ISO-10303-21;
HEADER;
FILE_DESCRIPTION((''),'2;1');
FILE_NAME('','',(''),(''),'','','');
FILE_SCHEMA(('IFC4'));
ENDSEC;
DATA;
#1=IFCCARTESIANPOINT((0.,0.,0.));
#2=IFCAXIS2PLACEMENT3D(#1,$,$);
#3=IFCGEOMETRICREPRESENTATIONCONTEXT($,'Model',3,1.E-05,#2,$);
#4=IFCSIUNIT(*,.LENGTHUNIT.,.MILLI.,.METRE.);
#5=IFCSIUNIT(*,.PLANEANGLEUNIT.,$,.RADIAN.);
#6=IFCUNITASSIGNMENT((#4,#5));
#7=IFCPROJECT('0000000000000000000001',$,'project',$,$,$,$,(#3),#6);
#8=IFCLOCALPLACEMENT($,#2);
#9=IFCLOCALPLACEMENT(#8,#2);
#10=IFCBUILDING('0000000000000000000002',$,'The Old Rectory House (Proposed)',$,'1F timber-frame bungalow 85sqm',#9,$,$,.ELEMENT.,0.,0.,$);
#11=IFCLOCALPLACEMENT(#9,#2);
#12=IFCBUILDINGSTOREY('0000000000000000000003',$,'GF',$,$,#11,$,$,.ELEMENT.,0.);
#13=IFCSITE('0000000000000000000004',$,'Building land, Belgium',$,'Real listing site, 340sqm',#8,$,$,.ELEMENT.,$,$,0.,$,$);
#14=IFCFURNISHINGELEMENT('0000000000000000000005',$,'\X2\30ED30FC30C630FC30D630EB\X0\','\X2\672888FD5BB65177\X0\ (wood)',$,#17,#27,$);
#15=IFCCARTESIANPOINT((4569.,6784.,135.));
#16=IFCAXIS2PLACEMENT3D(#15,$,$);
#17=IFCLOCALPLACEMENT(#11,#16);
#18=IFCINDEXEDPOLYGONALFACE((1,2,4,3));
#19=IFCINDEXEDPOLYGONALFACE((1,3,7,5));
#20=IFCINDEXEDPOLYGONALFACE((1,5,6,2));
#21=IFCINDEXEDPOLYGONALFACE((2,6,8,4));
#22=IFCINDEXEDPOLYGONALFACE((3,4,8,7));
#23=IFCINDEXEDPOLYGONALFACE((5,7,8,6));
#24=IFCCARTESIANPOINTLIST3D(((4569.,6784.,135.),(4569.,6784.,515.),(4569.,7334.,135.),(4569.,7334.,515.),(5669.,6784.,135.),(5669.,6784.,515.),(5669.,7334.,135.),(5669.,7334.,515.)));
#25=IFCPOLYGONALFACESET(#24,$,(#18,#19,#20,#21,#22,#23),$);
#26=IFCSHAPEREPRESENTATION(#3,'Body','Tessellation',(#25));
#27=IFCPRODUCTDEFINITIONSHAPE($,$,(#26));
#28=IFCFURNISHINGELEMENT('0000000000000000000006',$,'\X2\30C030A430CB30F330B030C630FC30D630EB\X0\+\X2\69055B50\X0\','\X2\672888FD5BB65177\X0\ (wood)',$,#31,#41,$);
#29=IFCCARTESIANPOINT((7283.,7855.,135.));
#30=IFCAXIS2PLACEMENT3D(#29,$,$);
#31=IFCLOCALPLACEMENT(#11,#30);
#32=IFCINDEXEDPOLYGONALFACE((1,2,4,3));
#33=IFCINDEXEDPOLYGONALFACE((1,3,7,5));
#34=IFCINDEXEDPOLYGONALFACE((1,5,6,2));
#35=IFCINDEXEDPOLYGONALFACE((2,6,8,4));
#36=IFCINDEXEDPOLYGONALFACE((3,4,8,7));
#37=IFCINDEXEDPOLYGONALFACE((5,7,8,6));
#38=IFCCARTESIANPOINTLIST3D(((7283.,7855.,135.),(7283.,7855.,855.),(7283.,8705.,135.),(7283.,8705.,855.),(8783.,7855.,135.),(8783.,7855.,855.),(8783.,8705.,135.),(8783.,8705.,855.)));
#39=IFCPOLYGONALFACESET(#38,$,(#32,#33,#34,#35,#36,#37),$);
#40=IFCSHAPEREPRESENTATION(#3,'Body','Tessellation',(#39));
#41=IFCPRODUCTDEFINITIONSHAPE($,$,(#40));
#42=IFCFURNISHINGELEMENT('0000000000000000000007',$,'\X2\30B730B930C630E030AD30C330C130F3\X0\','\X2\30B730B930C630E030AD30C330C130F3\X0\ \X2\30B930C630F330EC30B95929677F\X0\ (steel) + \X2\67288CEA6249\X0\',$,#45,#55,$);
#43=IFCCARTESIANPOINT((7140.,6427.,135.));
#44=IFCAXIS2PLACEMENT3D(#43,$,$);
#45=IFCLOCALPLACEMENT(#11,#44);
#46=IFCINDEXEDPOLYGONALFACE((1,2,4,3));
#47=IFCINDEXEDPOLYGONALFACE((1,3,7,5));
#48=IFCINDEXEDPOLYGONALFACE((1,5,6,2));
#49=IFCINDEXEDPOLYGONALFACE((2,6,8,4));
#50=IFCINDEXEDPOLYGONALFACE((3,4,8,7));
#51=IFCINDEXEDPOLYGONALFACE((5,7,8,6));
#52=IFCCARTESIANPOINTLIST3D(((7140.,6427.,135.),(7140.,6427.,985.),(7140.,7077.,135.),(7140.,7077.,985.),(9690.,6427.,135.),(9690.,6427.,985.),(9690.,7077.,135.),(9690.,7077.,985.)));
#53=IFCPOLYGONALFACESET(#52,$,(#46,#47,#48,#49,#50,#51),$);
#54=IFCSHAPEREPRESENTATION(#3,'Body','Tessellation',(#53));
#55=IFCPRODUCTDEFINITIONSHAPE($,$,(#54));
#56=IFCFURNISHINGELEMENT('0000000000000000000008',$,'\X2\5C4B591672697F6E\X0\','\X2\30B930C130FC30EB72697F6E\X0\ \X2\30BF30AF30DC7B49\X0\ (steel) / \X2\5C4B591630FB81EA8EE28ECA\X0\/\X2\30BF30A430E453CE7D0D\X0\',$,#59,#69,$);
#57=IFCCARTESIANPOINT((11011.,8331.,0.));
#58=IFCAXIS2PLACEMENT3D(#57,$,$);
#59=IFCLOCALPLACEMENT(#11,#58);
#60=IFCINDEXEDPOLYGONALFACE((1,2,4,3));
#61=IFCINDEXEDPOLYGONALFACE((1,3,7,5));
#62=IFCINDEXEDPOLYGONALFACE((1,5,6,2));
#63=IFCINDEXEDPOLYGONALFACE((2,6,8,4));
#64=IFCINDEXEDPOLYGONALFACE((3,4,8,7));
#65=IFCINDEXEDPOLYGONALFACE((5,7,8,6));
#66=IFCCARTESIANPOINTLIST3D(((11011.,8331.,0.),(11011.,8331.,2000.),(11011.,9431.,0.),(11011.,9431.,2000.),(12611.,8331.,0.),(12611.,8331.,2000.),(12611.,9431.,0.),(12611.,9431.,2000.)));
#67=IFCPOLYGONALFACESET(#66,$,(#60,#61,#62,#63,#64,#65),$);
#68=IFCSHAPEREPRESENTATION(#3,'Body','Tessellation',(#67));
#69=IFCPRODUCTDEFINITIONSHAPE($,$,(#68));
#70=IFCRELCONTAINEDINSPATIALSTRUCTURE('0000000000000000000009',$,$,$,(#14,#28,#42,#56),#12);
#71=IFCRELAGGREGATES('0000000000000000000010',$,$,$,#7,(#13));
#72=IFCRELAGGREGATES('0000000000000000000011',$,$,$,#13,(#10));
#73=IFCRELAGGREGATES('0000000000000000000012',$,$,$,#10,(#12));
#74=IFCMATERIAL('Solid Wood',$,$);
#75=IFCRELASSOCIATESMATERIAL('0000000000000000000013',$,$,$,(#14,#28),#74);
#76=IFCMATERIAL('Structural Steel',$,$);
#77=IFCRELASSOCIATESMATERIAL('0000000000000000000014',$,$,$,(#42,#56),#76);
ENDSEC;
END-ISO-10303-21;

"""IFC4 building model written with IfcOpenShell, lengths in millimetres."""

from ifc_helpers import new_model, si_unit, frame, frame_2d, origin, place, context, project, spatial, rectangle, extrude, material, element, save


model = new_model("IFC4")

# Units and contexts
model_context = context("Model", 3, precision=1e-05, world=origin())
ifc_project = project(units=[si_unit("LENGTHUNIT", "METRE", prefix="MILLI"), si_unit("PLANEANGLEUNIT", "RADIAN")], contexts=[model_context])

# Site, building, storey
site_placement = place(None, origin())
site = spatial("IfcSite", under=ifc_project, at=site_placement, Name="Building land, Belgium", ObjectType="Real listing site, 340sqm", CompositionType="ELEMENT", RefElevation=0.0)
building_placement = place(site_placement, origin())
building = spatial("IfcBuilding", under=site, at=building_placement, Name="The Old Rectory House (Proposed)", ObjectType="1F timber-frame bungalow 85sqm", CompositionType="ELEMENT", ElevationOfRefHeight=0.0, ElevationOfTerrain=0.0)
storey_placement = place(building_placement, origin())
storey = spatial("IfcBuildingStorey", under=building, at=storey_placement, Name="GF", CompositionType="ELEMENT", Elevation=0.0)

# Shared definitions
ifc_material_1 = material(Name="Solid Wood")

# Shared definitions
ifc_material_2 = material(Name="Structural Steel")

# Furnishing elements
furnishing_1_placement = place(storey_placement, frame((4569.0, 6784.0, 135.0)))
element("IfcFurnishingElement", 1, at=furnishing_1_placement, inside=storey, material=ifc_material_1, Name="ローテーブル", Description="木製家具 (wood)", context=model_context, shape_type="SweptSolid", body=[
    extrude(rectangle(XDim=1100.0, YDim=550.0, at=frame_2d((550.0, 275.0))), frame((4569.0, 6784.0, 135.0)), (0.0, 0.0, 1.0), 380.0),
])
furnishing_2_placement = place(storey_placement, frame((7283.0, 7855.0, 135.0)))
element("IfcFurnishingElement", 2, at=furnishing_2_placement, inside=storey, material=ifc_material_1, Name="ダイニングテーブル+椅子", Description="木製家具 (wood)", context=model_context, shape_type="SweptSolid", body=[
    extrude(rectangle(XDim=1500.0, YDim=850.0, at=frame_2d((750.0, 425.0))), frame((7283.0, 7855.0, 135.0)), (0.0, 0.0, 1.0), 720.0),
])
furnishing_3_placement = place(storey_placement, frame((7140.0, 6427.0, 135.0)))
element("IfcFurnishingElement", 3, at=furnishing_3_placement, inside=storey, material=ifc_material_2, Name="システムキッチン", Description="システムキッチン ステンレス天板 (steel) + 木質扉", context=model_context, shape_type="SweptSolid", body=[
    extrude(rectangle(XDim=2550.0, YDim=650.0, at=frame_2d((1275.0, 325.0))), frame((7140.0, 6427.0, 135.0)), (0.0, 0.0, 1.0), 850.0),
])
furnishing_4_placement = place(storey_placement, frame((11011.0, 8331.0, 0.0)))
element("IfcFurnishingElement", 4, at=furnishing_4_placement, inside=storey, material=ifc_material_2, Name="屋外物置", Description="スチール物置 タクボ等 (steel) / 屋外・自転車/タイヤ収納", context=model_context, shape_type="SweptSolid", body=[
    extrude(rectangle(XDim=1600.0, YDim=1100.0, at=frame_2d((800.0, 550.0))), frame((11011.0, 8331.0, 0.0)), (0.0, 0.0, 1.0), 2000.0),
])

save(model, "model.ifc")
